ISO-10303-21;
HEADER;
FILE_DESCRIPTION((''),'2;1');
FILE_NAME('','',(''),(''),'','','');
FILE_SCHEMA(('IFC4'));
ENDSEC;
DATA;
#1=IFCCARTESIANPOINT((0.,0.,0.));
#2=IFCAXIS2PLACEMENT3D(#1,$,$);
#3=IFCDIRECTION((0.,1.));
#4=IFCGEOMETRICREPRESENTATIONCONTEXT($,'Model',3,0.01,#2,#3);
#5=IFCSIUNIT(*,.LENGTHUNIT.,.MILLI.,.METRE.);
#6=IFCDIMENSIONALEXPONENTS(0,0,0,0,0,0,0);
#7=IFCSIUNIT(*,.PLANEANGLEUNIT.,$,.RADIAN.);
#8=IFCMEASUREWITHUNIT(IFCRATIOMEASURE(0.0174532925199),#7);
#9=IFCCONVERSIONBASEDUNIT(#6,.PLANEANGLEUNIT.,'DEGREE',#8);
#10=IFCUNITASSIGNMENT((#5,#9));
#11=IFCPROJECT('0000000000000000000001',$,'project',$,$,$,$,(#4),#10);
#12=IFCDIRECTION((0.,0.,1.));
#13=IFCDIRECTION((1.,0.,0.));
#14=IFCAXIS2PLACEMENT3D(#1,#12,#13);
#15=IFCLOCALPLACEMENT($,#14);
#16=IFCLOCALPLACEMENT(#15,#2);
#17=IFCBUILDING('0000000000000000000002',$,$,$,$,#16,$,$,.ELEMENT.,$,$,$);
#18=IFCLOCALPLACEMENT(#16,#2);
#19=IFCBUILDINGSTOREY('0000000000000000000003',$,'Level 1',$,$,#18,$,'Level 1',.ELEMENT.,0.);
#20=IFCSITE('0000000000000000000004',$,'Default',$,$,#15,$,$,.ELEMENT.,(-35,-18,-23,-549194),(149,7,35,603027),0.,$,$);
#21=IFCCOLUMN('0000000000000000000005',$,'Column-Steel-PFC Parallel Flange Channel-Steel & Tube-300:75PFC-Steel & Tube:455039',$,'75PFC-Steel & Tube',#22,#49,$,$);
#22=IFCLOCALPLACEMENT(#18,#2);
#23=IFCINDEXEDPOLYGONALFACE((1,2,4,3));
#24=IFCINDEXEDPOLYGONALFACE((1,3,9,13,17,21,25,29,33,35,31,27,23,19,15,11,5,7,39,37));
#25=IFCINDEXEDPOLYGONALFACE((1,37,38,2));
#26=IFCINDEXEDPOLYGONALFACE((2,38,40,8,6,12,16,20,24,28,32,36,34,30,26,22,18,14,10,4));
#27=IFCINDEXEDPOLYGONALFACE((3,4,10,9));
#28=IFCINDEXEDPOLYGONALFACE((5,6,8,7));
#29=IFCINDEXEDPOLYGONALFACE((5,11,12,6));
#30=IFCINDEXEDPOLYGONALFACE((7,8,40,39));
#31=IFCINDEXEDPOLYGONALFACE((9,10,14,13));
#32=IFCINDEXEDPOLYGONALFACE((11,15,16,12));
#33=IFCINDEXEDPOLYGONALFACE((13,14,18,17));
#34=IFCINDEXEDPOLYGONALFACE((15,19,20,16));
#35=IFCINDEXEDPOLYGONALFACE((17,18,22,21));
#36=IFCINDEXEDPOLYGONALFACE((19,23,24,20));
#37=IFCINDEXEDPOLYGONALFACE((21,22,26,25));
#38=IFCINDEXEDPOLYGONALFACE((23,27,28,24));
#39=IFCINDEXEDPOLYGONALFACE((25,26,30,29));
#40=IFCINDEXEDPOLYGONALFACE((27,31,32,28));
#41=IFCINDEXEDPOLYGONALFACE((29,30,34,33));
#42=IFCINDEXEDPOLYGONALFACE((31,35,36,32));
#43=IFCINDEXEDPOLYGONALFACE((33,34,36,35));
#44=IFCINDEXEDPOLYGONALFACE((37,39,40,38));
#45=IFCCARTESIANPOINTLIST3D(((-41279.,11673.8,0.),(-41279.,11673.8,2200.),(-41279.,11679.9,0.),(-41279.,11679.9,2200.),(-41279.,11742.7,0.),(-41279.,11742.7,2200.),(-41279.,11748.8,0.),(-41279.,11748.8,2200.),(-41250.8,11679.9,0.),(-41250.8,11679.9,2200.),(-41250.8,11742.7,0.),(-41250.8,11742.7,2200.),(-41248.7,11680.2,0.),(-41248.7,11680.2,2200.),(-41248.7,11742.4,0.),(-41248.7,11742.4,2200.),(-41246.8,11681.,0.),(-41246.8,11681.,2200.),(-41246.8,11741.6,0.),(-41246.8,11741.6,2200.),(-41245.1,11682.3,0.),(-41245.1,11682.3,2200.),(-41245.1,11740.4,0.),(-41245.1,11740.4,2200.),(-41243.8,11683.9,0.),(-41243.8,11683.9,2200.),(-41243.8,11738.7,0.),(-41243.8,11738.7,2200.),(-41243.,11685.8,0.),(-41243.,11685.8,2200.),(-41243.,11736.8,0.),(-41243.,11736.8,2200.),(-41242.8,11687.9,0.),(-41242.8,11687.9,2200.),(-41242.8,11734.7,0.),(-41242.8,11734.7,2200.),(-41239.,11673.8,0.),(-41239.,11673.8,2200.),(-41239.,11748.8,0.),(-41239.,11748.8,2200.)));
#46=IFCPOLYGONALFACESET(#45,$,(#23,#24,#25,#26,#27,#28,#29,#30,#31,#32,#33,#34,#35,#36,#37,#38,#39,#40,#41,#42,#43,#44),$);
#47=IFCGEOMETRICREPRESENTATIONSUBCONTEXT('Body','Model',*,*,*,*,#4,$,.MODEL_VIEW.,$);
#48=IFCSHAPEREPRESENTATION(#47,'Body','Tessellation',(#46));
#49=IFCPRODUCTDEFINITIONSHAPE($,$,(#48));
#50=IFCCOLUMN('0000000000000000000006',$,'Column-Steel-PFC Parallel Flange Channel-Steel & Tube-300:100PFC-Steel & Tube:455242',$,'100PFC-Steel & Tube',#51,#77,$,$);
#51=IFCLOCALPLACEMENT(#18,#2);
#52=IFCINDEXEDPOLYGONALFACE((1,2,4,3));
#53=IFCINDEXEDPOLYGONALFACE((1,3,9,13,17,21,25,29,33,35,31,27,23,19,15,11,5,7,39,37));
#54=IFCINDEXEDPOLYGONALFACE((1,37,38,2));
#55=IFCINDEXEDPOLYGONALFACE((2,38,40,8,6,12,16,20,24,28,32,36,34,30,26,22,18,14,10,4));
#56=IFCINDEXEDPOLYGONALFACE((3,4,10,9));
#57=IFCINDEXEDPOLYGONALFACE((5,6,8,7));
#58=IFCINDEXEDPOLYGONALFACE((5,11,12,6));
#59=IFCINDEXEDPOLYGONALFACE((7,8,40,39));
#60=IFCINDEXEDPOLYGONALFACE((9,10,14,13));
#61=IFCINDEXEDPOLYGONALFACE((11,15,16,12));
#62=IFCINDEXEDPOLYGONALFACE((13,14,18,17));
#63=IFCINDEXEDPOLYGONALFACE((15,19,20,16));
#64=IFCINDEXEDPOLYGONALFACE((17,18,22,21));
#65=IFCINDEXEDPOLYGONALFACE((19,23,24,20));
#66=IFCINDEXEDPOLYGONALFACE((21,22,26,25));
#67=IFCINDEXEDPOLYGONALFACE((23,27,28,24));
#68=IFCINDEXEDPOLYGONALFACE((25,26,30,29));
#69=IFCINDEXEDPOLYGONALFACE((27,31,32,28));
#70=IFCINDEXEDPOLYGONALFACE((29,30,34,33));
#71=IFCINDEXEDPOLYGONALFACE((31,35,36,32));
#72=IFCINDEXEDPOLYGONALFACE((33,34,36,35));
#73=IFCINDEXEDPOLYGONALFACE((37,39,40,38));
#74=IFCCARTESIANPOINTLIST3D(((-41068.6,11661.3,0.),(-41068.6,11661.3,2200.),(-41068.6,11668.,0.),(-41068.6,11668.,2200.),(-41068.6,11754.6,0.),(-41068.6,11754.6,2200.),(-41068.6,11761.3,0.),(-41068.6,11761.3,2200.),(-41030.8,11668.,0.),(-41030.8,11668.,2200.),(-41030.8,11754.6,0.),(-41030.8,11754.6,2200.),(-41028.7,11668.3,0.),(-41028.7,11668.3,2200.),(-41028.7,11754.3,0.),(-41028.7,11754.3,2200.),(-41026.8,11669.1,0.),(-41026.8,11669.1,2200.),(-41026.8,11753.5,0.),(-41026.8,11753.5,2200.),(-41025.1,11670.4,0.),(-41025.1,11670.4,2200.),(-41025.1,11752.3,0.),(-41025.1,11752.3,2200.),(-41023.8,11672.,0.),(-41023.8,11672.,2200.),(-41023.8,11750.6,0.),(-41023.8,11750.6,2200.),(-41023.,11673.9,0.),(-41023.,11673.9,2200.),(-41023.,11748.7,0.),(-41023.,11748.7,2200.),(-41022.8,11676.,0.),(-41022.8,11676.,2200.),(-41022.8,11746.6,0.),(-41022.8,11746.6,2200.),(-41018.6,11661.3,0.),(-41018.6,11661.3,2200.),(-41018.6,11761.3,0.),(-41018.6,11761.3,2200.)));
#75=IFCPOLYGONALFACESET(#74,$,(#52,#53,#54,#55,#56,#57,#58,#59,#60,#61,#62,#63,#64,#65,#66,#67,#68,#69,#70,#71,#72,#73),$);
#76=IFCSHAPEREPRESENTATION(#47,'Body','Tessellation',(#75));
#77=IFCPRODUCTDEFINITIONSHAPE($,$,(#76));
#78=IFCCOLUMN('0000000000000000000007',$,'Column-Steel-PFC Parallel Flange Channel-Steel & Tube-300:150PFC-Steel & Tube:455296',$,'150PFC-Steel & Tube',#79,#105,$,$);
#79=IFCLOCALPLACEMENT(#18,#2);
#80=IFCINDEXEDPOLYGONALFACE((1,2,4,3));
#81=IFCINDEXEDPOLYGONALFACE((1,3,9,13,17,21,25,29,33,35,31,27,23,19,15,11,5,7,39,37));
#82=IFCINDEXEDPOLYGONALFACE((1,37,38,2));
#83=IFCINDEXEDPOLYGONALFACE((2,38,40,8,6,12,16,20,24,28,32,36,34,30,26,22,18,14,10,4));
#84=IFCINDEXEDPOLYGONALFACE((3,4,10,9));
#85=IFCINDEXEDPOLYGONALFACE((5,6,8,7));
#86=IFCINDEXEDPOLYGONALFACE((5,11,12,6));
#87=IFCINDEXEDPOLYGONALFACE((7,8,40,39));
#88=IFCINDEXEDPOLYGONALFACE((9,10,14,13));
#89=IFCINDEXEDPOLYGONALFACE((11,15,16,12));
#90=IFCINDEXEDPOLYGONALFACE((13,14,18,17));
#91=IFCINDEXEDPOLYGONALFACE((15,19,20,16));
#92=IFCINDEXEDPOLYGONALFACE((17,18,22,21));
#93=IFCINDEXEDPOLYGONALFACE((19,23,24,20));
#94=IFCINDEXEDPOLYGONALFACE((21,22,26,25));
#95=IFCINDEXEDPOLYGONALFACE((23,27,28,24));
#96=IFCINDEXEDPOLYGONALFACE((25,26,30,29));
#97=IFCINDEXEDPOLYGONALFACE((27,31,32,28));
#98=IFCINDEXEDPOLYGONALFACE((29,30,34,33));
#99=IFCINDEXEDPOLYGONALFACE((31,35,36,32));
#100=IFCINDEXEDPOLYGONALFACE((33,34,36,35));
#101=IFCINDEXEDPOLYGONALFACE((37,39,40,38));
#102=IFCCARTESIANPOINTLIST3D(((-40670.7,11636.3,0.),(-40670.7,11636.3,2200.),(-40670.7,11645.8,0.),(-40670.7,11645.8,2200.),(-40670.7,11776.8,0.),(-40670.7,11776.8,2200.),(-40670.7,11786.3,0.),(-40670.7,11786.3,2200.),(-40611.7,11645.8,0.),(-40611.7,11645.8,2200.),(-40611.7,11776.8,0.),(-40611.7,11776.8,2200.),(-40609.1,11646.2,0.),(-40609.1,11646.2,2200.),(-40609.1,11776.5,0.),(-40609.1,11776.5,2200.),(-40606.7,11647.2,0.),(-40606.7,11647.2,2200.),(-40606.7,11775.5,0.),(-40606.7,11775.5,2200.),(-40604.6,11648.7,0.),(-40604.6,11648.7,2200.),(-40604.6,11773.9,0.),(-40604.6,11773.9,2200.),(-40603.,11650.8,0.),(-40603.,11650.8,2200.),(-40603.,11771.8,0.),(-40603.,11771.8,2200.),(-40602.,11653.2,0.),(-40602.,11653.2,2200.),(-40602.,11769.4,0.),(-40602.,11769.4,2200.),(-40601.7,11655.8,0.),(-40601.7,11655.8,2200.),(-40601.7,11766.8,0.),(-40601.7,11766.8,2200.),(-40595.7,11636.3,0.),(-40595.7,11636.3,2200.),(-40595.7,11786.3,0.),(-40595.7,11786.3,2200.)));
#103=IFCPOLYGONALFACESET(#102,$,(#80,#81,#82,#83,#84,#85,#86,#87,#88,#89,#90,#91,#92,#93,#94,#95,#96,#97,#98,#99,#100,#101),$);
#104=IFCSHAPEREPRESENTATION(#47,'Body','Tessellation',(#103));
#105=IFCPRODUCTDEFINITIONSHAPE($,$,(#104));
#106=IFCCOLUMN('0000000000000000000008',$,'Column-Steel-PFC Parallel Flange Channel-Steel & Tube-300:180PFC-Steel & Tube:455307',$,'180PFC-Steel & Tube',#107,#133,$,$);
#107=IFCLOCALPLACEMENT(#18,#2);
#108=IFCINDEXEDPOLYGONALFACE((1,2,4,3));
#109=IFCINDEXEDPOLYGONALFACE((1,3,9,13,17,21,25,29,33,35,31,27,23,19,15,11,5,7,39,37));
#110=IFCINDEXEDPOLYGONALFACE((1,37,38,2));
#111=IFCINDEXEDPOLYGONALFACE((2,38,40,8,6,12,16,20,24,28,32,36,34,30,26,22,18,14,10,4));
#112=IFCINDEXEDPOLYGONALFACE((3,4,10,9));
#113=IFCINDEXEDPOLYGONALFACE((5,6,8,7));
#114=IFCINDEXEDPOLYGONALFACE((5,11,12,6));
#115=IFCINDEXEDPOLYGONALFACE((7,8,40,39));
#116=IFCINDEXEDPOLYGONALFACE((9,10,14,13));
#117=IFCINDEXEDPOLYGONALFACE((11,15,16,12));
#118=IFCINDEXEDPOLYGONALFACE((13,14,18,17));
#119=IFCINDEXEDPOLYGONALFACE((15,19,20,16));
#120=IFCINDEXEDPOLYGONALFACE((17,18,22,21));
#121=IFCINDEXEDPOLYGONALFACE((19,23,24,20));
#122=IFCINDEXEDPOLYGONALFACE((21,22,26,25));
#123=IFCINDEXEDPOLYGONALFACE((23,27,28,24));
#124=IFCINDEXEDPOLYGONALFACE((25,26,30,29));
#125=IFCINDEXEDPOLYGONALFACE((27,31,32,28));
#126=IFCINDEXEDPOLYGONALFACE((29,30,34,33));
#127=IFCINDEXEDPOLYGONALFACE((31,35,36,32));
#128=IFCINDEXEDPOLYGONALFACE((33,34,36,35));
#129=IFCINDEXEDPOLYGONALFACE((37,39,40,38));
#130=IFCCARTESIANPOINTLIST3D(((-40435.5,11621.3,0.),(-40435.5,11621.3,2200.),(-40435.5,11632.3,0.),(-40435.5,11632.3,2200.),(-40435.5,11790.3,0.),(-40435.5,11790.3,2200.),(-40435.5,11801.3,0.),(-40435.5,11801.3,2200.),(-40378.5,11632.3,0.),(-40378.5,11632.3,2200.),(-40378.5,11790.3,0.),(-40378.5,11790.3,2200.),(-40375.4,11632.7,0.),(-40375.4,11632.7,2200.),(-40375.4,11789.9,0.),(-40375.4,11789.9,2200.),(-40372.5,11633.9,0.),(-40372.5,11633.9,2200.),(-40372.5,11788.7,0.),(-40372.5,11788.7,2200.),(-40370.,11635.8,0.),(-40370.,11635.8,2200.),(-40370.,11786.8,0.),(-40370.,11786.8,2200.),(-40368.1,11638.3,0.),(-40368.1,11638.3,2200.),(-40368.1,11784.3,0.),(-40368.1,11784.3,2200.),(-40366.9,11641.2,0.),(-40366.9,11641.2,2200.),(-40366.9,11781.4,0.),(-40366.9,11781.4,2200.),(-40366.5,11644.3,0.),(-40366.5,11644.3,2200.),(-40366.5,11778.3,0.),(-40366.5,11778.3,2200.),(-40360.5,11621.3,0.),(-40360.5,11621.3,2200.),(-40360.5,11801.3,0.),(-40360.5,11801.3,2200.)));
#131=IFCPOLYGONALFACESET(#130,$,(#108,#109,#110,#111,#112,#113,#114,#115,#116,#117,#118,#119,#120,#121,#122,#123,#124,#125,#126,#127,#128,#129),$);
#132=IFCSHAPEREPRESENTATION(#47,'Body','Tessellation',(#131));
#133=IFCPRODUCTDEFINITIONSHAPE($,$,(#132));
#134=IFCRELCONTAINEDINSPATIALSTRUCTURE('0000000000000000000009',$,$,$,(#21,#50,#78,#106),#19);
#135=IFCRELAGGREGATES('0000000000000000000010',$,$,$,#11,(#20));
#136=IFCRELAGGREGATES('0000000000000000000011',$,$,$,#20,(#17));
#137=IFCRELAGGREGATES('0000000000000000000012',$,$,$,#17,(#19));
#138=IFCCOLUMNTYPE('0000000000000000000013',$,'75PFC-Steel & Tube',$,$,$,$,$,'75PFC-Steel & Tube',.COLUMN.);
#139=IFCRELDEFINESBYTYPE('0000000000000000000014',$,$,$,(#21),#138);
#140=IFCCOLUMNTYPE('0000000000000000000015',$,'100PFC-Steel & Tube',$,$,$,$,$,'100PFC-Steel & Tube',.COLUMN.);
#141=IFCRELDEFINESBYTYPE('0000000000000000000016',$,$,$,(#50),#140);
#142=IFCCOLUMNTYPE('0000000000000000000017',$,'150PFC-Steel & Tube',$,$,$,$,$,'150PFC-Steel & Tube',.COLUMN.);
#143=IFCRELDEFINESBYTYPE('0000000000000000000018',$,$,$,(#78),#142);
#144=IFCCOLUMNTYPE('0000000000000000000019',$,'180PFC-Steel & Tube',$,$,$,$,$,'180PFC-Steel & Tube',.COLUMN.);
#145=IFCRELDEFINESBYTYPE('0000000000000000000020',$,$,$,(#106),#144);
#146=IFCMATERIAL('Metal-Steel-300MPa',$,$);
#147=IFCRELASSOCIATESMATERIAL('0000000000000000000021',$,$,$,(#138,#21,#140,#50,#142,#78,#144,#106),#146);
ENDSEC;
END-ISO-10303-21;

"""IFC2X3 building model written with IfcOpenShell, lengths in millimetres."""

from ifc_helpers import new_model, entity, si_unit, converted_unit, direction, frame, frame_2d, origin, origin_with_axes, place, context, subcontext, project, spatial, polyline, circle_curve, parameter, trimmed, segment, composite_curve, outline, extrude, source, transform, mapped, material, type_object, type_shapes, element, save


model = new_model("IFC2X3")

# Units and contexts
model_context = context("Model", 3, precision=0.01, world=origin(), true_north=direction((0.0, 1.0)))
body_context = subcontext(model_context, "Body", "Model", "MODEL_VIEW")
ifc_project = project(units=[si_unit("LENGTHUNIT", "METRE", prefix="MILLI"), converted_unit("PLANEANGLEUNIT", "DEGREE", entity("IfcRatioMeasure", 0.0174532925199), si_unit("PLANEANGLEUNIT", "RADIAN"), dimensions=[0, 0, 0, 0, 0, 0, 0])], contexts=[model_context])

# Site, building, storey
site_placement = place(None, origin_with_axes())
site = spatial("IfcSite", under=ifc_project, at=site_placement, Name="Default", CompositionType="ELEMENT", RefLatitude=(-35, -18, -23, -549194), RefLongitude=(149, 7, 35, 603027), RefElevation=0.0)
building_placement = place(site_placement, origin())
building = spatial("IfcBuilding", under=site, at=building_placement, CompositionType="ELEMENT")
storey_placement = place(building_placement, origin())
storey = spatial("IfcBuildingStorey", under=building, at=storey_placement, Name="Level 1", LongName="Level 1", CompositionType="ELEMENT", Elevation=0.0)

# Columns
ifc_material = material(Name="Metal-Steel-300MPa")
column_type_1 = type_object("IfcColumnType", Name="75PFC-Steel & Tube", ElementType="75PFC-Steel & Tube", PredefinedType="COLUMN", material=ifc_material)
shared_shape_1 = source(origin(), body_context, "Body", "SweptSolid", [
    extrude(outline(composite_curve([segment(polyline([(31.4, -20.9), (37.5, -20.9)]), True, "CONTINUOUS"), segment(polyline([(37.5, -20.9), (37.5, 19.1)]), True, "CONTINUOUS"), segment(polyline([(37.5, 19.1), (-37.5, 19.1)]), True, "CONTINUOUS"), segment(polyline([(-37.5, 19.1), (-37.5, -20.9)]), True, "CONTINUOUS"), segment(polyline([(-37.5, -20.9), (-31.4, -20.9)]), True, "CONTINUOUS"), segment(polyline([(-31.4, -20.9), (-31.4, 7.3)]), True, "CONTINUOUS"), segment(trimmed(circle_curve(frame_2d((-23.4, 7.3), x_axis=(-1.0, 0.0)), 8.0), [parameter(270.0)], [parameter(0.0)], True, "PARAMETER"), False, "CONTINUOUS"), segment(polyline([(-23.4, 15.3), (23.4, 15.3)]), True, "CONTINUOUS"), segment(trimmed(circle_curve(frame_2d((23.4, 7.3), x_axis=(0.0, 1.0)), 8.0), [parameter(270.0)], [parameter(0.0)], True, "PARAMETER"), False, "CONTINUOUS"), segment(polyline([(31.4, 7.3), (31.4, -20.9)]), True, "CONTINUOUS")], self_intersect=False)), frame((0.9, 0.0, 0.0), z_axis=(0.0, 0.0, 1.0), x_axis=(0.0, -1.0, 0.0)), (0.0, 0.0, 1.0), 2200.0),
])
type_shapes(column_type_1, [shared_shape_1])
column_1_placement = place(storey_placement, frame((-41259.0, 11711.3, 0.0)))
element("IfcColumn", 1, at=column_1_placement, inside=storey, type_object=column_type_1, material=ifc_material, Name="Column-Steel-PFC Parallel Flange Channel-Steel & Tube-300:75PFC-Steel & Tube:455039", ObjectType="75PFC-Steel & Tube", context=body_context, shape_type="MappedRepresentation", body=[
    mapped(shared_shape_1, transform((0.0, 0.0, 0.0), scale=1.0)),
])
column_type_2 = type_object("IfcColumnType", Name="100PFC-Steel & Tube", ElementType="100PFC-Steel & Tube", PredefinedType="COLUMN", material=ifc_material)
shared_shape_2 = source(origin(), body_context, "Body", "SweptSolid", [
    extrude(outline(composite_curve([segment(polyline([(43.3, -26.7), (50.0, -26.7)]), True, "CONTINUOUS"), segment(polyline([(50.0, -26.7), (50.0, 23.3)]), True, "CONTINUOUS"), segment(polyline([(50.0, 23.3), (-50.0, 23.3)]), True, "CONTINUOUS"), segment(polyline([(-50.0, 23.3), (-50.0, -26.7)]), True, "CONTINUOUS"), segment(polyline([(-50.0, -26.7), (-43.3, -26.7)]), True, "CONTINUOUS"), segment(polyline([(-43.3, -26.7), (-43.3, 11.1)]), True, "CONTINUOUS"), segment(trimmed(circle_curve(frame_2d((-35.3, 11.1), x_axis=(-1.0, 0.0)), 8.0), [parameter(270.0)], [parameter(0.0)], True, "PARAMETER"), False, "CONTINUOUS"), segment(polyline([(-35.3, 19.1), (35.3, 19.1)]), True, "CONTINUOUS"), segment(trimmed(circle_curve(frame_2d((35.3, 11.1), x_axis=(0.0, 1.0)), 8.0), [parameter(270.0)], [parameter(0.0)], True, "PARAMETER"), False, "CONTINUOUS"), segment(polyline([(43.3, 11.1), (43.3, -26.7)]), True, "CONTINUOUS")], self_intersect=False)), frame((1.7, 0.0, 0.0), z_axis=(0.0, 0.0, 1.0), x_axis=(0.0, -1.0, 0.0)), (0.0, 0.0, 1.0), 2200.0),
])
type_shapes(column_type_2, [shared_shape_2])
column_2_placement = place(storey_placement, frame((-41043.6, 11711.3, 0.0)))
element("IfcColumn", 2, at=column_2_placement, inside=storey, type_object=column_type_2, material=ifc_material, Name="Column-Steel-PFC Parallel Flange Channel-Steel & Tube-300:100PFC-Steel & Tube:455242", ObjectType="100PFC-Steel & Tube", context=body_context, shape_type="MappedRepresentation", body=[
    mapped(shared_shape_2, transform((0.0, 0.0, 0.0), scale=1.0)),
])
column_type_3 = type_object("IfcColumnType", Name="150PFC-Steel & Tube", ElementType="150PFC-Steel & Tube", PredefinedType="COLUMN", material=ifc_material)
shared_shape_3 = source(origin(), body_context, "Body", "SweptSolid", [
    extrude(outline(composite_curve([segment(polyline([(65.5, -40.6), (75.0, -40.6)]), True, "CONTINUOUS"), segment(polyline([(75.0, -40.6), (75.0, 34.4)]), True, "CONTINUOUS"), segment(polyline([(75.0, 34.4), (-75.0, 34.4)]), True, "CONTINUOUS"), segment(polyline([(-75.0, 34.4), (-75.0, -40.6)]), True, "CONTINUOUS"), segment(polyline([(-75.0, -40.6), (-65.5, -40.6)]), True, "CONTINUOUS"), segment(polyline([(-65.5, -40.6), (-65.5, 18.4)]), True, "CONTINUOUS"), segment(trimmed(circle_curve(frame_2d((-55.5, 18.4), x_axis=(-1.0, 0.0)), 10.0), [parameter(270.0)], [parameter(0.0)], True, "PARAMETER"), False, "CONTINUOUS"), segment(polyline([(-55.5, 28.4), (55.5, 28.4)]), True, "CONTINUOUS"), segment(trimmed(circle_curve(frame_2d((55.5, 18.4), x_axis=(0.0, 1.0)), 10.0), [parameter(270.0)], [parameter(0.0)], True, "PARAMETER"), False, "CONTINUOUS"), segment(polyline([(65.5, 18.4), (65.5, -40.6)]), True, "CONTINUOUS")], self_intersect=False)), frame((3.1, 0.0, 0.0), z_axis=(0.0, 0.0, 1.0), x_axis=(0.0, -1.0, 0.0)), (0.0, 0.0, 1.0), 2200.0),
])
type_shapes(column_type_3, [shared_shape_3])
column_3_placement = place(storey_placement, frame((-40633.2, 11711.3, 0.0)))
element("IfcColumn", 3, at=column_3_placement, inside=storey, type_object=column_type_3, material=ifc_material, Name="Column-Steel-PFC Parallel Flange Channel-Steel & Tube-300:150PFC-Steel & Tube:455296", ObjectType="150PFC-Steel & Tube", context=body_context, shape_type="MappedRepresentation", body=[
    mapped(shared_shape_3, transform((0.0, 0.0, 0.0), scale=1.0)),
])
column_type_4 = type_object("IfcColumnType", Name="180PFC-Steel & Tube", ElementType="180PFC-Steel & Tube", PredefinedType="COLUMN", material=ifc_material)
shared_shape_4 = source(origin(), body_context, "Body", "SweptSolid", [
    extrude(outline(composite_curve([segment(polyline([(79.0, -40.2), (90.0, -40.2)]), True, "CONTINUOUS"), segment(polyline([(90.0, -40.2), (90.0, 34.8)]), True, "CONTINUOUS"), segment(polyline([(90.0, 34.8), (-90.0, 34.8)]), True, "CONTINUOUS"), segment(polyline([(-90.0, 34.8), (-90.0, -40.2)]), True, "CONTINUOUS"), segment(polyline([(-90.0, -40.2), (-79.0, -40.2)]), True, "CONTINUOUS"), segment(polyline([(-79.0, -40.2), (-79.0, 16.8)]), True, "CONTINUOUS"), segment(trimmed(circle_curve(frame_2d((-67.0, 16.8), x_axis=(-1.0, 0.0)), 12.0), [parameter(270.0)], [parameter(0.0)], True, "PARAMETER"), False, "CONTINUOUS"), segment(polyline([(-67.0, 28.8), (67.0, 28.8)]), True, "CONTINUOUS"), segment(trimmed(circle_curve(frame_2d((67.0, 16.8), x_axis=(0.0, 1.0)), 12.0), [parameter(270.0)], [parameter(0.0)], True, "PARAMETER"), False, "CONTINUOUS"), segment(polyline([(79.0, 16.8), (79.0, -40.2)]), True, "CONTINUOUS")], self_intersect=False)), frame((2.7, 0.0, 0.0), z_axis=(0.0, 0.0, 1.0), x_axis=(0.0, -1.0, 0.0)), (0.0, 0.0, 1.0), 2200.0),
])
type_shapes(column_type_4, [shared_shape_4])
column_4_placement = place(storey_placement, frame((-40398.0, 11711.3, 0.0)))
element("IfcColumn", 4, at=column_4_placement, inside=storey, type_object=column_type_4, material=ifc_material, Name="Column-Steel-PFC Parallel Flange Channel-Steel & Tube-300:180PFC-Steel & Tube:455307", ObjectType="180PFC-Steel & Tube", context=body_context, shape_type="MappedRepresentation", body=[
    mapped(shared_shape_4, transform((0.0, 0.0, 0.0), scale=1.0)),
])

save(model, "model.ifc")
